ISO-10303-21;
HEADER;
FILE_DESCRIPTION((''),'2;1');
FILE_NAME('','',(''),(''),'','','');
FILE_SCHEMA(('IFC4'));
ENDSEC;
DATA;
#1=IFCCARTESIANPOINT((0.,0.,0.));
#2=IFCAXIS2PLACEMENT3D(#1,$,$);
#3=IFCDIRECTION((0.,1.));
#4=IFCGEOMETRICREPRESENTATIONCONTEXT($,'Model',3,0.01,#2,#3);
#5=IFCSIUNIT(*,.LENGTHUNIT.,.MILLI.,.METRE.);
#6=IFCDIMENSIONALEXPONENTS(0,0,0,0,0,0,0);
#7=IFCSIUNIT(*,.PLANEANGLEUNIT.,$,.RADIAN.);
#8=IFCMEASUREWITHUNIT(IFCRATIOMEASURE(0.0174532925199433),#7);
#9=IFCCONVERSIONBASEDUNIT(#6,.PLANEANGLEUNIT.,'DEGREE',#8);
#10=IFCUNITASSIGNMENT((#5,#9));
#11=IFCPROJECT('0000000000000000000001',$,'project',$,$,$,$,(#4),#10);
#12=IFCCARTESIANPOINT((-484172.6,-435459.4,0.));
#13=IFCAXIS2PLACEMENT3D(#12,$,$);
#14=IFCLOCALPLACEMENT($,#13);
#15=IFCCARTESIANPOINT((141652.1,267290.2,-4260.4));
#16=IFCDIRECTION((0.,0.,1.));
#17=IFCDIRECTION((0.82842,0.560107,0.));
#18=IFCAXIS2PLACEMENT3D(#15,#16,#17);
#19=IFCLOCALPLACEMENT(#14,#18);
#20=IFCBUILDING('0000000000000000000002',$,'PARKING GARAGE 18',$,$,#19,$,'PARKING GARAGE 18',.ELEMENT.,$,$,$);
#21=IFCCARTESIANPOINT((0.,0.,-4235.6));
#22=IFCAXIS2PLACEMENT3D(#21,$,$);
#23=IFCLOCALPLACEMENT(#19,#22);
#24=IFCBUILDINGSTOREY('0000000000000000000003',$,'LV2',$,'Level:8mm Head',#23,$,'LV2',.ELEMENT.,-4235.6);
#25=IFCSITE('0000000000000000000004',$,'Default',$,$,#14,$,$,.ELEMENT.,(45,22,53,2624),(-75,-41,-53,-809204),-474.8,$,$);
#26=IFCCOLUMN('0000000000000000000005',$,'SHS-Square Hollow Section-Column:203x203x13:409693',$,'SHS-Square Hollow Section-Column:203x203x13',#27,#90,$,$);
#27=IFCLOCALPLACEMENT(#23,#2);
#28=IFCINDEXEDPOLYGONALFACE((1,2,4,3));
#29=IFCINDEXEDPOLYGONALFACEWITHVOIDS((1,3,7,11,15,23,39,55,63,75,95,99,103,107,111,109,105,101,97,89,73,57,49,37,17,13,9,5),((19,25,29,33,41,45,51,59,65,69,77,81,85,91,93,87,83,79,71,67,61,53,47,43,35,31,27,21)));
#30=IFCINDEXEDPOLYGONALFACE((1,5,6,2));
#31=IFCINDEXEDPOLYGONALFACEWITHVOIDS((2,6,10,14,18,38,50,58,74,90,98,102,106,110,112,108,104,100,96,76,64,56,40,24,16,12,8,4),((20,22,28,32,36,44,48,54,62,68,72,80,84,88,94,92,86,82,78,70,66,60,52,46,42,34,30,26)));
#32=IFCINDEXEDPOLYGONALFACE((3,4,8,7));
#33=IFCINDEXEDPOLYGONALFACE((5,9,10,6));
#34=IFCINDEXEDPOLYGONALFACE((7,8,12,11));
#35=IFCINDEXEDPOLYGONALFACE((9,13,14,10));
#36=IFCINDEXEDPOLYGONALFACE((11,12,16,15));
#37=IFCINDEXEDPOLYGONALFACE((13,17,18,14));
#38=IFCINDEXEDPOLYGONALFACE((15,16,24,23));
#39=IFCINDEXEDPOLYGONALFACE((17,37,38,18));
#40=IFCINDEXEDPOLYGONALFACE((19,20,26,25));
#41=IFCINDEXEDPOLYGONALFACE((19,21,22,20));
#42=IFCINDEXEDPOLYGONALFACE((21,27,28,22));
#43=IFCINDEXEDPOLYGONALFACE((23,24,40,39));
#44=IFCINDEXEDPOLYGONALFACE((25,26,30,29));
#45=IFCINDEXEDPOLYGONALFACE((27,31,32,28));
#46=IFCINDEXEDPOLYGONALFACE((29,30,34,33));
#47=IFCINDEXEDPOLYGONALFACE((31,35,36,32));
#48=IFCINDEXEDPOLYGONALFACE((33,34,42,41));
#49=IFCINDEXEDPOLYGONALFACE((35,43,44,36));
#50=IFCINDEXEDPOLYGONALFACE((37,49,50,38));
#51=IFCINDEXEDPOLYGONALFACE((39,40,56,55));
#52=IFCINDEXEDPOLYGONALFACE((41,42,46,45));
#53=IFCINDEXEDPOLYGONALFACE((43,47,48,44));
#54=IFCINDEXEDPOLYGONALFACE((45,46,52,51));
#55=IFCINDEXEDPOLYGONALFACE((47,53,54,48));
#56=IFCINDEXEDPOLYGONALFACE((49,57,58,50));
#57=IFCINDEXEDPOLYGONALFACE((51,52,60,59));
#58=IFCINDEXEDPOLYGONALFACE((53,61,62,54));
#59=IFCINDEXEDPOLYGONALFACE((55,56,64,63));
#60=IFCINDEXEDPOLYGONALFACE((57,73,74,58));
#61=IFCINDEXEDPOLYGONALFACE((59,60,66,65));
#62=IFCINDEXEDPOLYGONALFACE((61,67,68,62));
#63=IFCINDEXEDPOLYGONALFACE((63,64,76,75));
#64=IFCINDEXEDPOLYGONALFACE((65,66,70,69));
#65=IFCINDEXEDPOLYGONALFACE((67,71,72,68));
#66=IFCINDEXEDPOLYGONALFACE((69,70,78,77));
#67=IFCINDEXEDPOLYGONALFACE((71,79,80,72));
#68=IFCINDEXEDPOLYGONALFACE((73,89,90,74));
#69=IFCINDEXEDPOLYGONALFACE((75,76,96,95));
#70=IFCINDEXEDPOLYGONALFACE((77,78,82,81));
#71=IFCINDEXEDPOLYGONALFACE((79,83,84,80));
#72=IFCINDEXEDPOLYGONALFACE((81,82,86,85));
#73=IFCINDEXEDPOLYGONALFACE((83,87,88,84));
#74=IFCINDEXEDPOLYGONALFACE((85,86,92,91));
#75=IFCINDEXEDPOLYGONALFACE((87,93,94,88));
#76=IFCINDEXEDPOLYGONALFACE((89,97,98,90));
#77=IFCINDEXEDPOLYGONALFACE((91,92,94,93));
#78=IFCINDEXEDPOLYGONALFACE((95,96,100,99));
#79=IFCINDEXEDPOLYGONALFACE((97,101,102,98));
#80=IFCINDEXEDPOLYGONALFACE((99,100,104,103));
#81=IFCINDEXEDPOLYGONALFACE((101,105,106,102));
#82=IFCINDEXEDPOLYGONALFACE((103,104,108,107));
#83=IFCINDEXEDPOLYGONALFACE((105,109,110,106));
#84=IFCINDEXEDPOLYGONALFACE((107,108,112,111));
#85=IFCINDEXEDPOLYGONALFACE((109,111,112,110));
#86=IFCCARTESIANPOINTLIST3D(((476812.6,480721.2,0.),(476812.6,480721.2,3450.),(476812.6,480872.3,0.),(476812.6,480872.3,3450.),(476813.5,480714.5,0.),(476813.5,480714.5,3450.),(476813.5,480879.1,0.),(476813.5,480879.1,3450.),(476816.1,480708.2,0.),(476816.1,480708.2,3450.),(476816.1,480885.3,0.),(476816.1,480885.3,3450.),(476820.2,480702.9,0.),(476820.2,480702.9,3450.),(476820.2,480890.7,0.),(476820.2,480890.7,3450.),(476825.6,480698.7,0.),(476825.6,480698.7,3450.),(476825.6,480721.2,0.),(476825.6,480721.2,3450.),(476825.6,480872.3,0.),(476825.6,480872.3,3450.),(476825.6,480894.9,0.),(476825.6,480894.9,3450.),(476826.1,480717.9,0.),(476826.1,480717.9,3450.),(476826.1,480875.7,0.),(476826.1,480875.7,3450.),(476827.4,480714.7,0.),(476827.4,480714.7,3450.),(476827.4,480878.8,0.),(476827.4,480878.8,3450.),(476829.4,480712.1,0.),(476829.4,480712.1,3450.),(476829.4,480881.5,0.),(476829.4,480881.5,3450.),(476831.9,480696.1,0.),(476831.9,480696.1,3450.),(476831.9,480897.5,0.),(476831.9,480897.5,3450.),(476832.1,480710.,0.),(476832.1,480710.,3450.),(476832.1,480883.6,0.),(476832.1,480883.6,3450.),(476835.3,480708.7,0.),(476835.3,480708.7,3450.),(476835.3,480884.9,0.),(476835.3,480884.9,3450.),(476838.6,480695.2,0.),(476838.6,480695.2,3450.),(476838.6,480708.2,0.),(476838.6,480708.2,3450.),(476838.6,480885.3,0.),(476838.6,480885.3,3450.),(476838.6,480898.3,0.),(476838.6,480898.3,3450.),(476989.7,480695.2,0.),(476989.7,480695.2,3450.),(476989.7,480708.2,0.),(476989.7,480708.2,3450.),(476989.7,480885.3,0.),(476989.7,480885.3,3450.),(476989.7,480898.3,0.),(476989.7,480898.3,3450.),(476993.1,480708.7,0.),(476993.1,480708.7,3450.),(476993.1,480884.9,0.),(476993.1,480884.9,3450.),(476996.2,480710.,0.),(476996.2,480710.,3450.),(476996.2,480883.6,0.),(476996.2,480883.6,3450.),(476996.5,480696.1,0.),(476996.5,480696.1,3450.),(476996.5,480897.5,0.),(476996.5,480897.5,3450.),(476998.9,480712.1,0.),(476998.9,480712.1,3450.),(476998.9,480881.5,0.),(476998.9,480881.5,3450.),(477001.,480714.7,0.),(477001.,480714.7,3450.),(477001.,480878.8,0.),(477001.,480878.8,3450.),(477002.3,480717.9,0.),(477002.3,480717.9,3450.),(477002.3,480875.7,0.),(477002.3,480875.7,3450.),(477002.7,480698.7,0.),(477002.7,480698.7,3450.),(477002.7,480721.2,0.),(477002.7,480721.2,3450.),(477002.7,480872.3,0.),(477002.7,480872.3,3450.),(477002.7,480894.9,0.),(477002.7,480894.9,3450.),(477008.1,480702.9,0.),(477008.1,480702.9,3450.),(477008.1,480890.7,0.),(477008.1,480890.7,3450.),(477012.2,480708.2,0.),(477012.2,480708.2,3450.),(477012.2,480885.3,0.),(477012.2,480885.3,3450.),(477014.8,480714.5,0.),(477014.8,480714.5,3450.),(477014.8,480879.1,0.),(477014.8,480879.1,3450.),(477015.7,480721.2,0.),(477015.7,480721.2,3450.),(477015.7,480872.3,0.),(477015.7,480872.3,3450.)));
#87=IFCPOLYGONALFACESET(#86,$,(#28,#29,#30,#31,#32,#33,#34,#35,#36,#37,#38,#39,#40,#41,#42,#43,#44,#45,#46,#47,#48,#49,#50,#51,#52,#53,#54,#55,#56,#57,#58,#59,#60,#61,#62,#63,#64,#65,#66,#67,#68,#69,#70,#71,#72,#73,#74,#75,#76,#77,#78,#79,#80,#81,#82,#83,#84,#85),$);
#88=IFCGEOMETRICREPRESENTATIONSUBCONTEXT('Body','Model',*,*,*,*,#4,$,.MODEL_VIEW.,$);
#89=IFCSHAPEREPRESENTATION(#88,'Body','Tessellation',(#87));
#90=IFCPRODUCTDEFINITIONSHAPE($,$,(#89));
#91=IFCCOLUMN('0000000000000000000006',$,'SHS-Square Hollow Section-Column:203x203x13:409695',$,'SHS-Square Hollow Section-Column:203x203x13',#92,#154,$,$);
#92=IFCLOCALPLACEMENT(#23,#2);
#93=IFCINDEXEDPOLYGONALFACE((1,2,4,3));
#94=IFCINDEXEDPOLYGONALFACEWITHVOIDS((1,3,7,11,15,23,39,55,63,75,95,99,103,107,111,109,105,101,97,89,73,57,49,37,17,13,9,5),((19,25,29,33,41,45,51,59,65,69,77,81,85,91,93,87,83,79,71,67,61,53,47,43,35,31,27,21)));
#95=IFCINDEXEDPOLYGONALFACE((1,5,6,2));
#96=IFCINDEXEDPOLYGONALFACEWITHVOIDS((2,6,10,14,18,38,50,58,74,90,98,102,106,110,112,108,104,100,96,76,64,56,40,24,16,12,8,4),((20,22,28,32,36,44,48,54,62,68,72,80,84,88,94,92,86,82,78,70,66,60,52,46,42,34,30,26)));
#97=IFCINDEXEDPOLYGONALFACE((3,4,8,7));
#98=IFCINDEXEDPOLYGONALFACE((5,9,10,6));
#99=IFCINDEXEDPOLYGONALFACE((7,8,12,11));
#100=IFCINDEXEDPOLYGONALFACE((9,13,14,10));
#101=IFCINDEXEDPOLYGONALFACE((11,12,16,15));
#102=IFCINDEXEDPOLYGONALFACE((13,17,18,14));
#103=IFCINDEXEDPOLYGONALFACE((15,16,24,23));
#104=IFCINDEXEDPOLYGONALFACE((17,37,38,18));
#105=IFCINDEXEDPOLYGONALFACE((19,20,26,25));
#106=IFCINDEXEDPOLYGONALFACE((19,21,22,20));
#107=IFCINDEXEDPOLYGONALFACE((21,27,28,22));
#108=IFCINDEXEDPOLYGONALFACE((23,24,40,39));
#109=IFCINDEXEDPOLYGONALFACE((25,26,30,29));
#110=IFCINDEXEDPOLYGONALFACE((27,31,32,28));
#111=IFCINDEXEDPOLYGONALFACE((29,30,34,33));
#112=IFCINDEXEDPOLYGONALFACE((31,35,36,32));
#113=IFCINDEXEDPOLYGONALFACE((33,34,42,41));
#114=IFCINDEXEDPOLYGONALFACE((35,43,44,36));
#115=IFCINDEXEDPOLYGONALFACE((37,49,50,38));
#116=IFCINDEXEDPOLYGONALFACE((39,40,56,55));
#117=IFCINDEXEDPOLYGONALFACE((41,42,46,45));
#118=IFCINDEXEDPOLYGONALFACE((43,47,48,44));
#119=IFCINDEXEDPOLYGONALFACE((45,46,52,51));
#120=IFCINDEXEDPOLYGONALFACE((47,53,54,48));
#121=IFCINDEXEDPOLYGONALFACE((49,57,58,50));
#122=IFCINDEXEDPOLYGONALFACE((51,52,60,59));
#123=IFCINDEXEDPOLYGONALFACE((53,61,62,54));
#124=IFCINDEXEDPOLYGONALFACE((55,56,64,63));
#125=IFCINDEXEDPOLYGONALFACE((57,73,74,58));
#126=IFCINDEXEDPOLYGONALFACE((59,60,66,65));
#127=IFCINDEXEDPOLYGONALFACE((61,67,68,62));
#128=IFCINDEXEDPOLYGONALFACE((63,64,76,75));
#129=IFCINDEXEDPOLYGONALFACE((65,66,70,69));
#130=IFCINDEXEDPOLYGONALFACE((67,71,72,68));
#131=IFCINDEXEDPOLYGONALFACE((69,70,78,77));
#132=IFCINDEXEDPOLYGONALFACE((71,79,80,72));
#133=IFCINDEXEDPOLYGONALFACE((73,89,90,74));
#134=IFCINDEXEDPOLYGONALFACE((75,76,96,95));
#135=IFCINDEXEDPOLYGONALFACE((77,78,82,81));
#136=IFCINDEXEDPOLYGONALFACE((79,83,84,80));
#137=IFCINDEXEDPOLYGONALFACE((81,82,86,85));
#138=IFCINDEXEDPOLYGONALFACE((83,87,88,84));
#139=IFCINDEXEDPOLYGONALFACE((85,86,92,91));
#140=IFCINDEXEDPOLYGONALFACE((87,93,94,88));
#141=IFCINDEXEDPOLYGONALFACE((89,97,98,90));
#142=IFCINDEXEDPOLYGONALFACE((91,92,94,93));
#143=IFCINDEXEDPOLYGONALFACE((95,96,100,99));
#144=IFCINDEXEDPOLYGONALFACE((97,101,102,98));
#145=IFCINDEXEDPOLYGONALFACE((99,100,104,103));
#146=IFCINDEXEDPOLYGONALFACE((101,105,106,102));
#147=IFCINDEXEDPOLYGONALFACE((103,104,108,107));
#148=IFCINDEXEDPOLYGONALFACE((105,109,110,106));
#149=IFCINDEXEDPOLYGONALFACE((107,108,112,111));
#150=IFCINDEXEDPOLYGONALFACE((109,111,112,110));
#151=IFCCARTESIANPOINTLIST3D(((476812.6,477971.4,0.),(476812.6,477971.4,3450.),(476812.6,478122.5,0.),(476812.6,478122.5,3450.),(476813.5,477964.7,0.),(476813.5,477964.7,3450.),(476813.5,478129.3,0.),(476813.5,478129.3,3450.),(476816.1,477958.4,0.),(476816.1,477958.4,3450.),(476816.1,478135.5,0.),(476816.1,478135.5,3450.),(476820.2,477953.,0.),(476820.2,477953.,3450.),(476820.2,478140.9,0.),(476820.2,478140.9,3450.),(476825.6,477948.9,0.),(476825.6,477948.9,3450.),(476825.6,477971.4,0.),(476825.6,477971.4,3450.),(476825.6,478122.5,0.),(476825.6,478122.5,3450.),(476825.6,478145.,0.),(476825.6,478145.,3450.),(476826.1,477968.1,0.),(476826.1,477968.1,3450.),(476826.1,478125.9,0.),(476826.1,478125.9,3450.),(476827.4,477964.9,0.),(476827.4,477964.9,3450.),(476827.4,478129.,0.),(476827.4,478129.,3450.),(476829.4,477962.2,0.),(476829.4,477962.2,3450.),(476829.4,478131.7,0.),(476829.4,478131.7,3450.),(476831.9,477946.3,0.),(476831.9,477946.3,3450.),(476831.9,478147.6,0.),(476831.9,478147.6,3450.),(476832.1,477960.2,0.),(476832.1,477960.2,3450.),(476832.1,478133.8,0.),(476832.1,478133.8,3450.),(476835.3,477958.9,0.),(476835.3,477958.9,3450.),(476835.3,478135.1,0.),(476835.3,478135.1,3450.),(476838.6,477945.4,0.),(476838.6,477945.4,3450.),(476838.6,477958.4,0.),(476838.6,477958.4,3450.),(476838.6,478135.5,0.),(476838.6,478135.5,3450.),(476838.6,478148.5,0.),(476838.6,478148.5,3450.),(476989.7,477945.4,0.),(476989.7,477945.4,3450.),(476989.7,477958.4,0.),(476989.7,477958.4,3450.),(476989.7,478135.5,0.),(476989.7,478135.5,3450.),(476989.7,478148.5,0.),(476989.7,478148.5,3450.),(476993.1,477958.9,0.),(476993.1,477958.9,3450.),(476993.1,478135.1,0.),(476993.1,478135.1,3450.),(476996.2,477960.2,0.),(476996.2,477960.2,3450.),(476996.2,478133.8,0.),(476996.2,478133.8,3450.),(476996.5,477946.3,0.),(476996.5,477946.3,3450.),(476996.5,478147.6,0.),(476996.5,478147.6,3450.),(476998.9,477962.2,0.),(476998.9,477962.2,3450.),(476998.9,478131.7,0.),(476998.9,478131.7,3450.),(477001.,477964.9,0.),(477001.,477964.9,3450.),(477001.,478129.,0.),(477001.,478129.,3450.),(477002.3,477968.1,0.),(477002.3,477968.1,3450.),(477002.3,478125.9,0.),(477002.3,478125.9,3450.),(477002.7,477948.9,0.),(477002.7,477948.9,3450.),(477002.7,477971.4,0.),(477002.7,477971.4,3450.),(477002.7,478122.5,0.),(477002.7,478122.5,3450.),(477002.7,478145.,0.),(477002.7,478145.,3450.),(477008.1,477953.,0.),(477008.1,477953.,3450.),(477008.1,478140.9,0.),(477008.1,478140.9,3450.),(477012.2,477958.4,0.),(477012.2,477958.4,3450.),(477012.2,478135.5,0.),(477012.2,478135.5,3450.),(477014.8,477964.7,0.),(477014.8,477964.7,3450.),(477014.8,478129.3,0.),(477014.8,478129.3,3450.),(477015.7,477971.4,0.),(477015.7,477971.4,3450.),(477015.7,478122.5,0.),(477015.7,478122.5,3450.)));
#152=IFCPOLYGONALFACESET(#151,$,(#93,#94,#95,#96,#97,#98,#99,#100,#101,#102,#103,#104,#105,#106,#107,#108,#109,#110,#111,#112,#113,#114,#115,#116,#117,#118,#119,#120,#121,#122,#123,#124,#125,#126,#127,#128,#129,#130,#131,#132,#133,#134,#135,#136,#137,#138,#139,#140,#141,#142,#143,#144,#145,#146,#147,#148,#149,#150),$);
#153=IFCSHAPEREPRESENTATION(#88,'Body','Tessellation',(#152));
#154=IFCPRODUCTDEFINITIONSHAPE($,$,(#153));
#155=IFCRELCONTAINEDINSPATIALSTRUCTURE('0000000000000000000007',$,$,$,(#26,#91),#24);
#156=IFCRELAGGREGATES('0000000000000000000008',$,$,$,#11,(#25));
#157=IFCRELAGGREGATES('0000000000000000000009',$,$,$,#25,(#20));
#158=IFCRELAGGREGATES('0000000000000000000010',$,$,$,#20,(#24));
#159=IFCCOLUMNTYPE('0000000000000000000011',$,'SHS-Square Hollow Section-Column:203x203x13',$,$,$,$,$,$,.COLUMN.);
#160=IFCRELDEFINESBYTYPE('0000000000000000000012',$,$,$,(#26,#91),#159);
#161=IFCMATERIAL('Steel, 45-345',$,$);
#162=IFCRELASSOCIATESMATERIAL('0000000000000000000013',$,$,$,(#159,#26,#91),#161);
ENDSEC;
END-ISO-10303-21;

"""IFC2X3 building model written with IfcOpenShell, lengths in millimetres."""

from ifc_helpers import new_model, entity, si_unit, converted_unit, direction, frame, frame_2d, origin, place, context, subcontext, project, spatial, polyline, circle_curve, parameter, trimmed, segment, composite_curve, outline, extrude, source, transform, mapped, material, type_object, type_shapes, element, save


model = new_model("IFC2X3")

# Units and contexts
model_context = context("Model", 3, precision=0.01, world=origin(), true_north=direction((0.0, 1.0)))
body_context = subcontext(model_context, "Body", "Model", "MODEL_VIEW")
ifc_project = project(units=[si_unit("LENGTHUNIT", "METRE", prefix="MILLI"), converted_unit("PLANEANGLEUNIT", "DEGREE", entity("IfcRatioMeasure", 0.0174532925199433), si_unit("PLANEANGLEUNIT", "RADIAN"), dimensions=[0, 0, 0, 0, 0, 0, 0])], contexts=[model_context])

# Site, building, storey
site_placement = place(None, frame((-484172.6, -435459.4, 0.0)))
site = spatial("IfcSite", under=ifc_project, at=site_placement, Name="Default", CompositionType="ELEMENT", RefLatitude=(45, 22, 53, 2624), RefLongitude=(-75, -41, -53, -809204), RefElevation=-474.8)
building_placement = place(site_placement, frame((141652.1, 267290.2, -4260.4), z_axis=(0.0, 0.0, 1.0), x_axis=(0.82842, 0.560107, 0.0)))
building = spatial("IfcBuilding", under=site, at=building_placement, Name="PARKING GARAGE 18", LongName="PARKING GARAGE 18", CompositionType="ELEMENT")
storey_placement = place(building_placement, frame((0.0, 0.0, -4235.6)))
storey = spatial("IfcBuildingStorey", under=building, at=storey_placement, Name="LV2", ObjectType="Level:8mm Head", LongName="LV2", CompositionType="ELEMENT", Elevation=-4235.6)

# Columns
ifc_material_1 = material(Name="Steel, 45-345")
column_type = type_object("IfcColumnType", Name="SHS-Square Hollow Section-Column:203x203x13", PredefinedType="COLUMN", material=ifc_material_1)
shared_shape_1 = source(origin(), body_context, "Body", "SweptSolid", [
    extrude(outline(composite_curve([segment(polyline([(-75.6, -101.5), (75.6, -101.5)]), True, "CONTINUOUS"), segment(trimmed(circle_curve(frame_2d((75.6, -75.6), x_axis=(-1.0, 0.0)), 26.0), [parameter(90.0)], [parameter(180.0)], True, "PARAMETER"), True, "CONTINUOUS"), segment(polyline([(101.5, -75.6), (101.5, 75.6)]), True, "CONTINUOUS"), segment(trimmed(circle_curve(frame_2d((75.5, 75.6), x_axis=(-1.0, 0.0)), 26.0), [parameter(180.0)], [parameter(270.0)], True, "PARAMETER"), True, "CONTINUOUS"), segment(polyline([(75.5, 101.6), (-75.5, 101.6)]), True, "CONTINUOUS"), segment(trimmed(circle_curve(frame_2d((-75.5, 75.5), x_axis=(-1.0, 0.0)), 26.0), [parameter(270.0)], [parameter(360.0)], True, "PARAMETER"), True, "CONTINUOUS"), segment(polyline([(-101.5, 75.5), (-101.5, -75.6)]), True, "CONTINUOUS"), segment(trimmed(circle_curve(frame_2d((-75.6, -75.6), x_axis=(-1.0, 0.0)), 26.0), [parameter(360.0)], [parameter(90.0)], True, "PARAMETER"), True, "CONTINUOUS")], self_intersect=False), holes=[composite_curve([segment(trimmed(circle_curve(frame_2d((-75.6, -75.6), x_axis=(-1.0, 0.0)), 13.0), [parameter(0.0)], [parameter(90.0)], True, "PARAMETER"), False, "CONTINUOUS"), segment(polyline([(-88.5, -75.6), (-88.5, 75.6)]), True, "CONTINUOUS"), segment(trimmed(circle_curve(frame_2d((-75.6, 75.6), x_axis=(-1.0, 0.0)), 13.0), [parameter(270.0)], [parameter(0.0)], True, "PARAMETER"), False, "CONTINUOUS"), segment(polyline([(-75.6, 88.6), (75.5, 88.6)]), True, "CONTINUOUS"), segment(trimmed(circle_curve(frame_2d((75.5, 75.5), x_axis=(-1.0, 0.0)), 13.0), [parameter(180.0)], [parameter(270.0)], True, "PARAMETER"), False, "CONTINUOUS"), segment(polyline([(88.6, 75.5), (88.6, -75.5)]), True, "CONTINUOUS"), segment(trimmed(circle_curve(frame_2d((75.6, -75.5), x_axis=(-1.0, 0.0)), 13.0), [parameter(90.0)], [parameter(180.0)], True, "PARAMETER"), False, "CONTINUOUS"), segment(polyline([(75.6, -88.5), (-75.6, -88.5)]), True, "CONTINUOUS")], self_intersect=False)]), frame((0.0, 0.0, -4235.6), z_axis=(0.0, 0.0, 1.0), x_axis=(-1.0, 0.0, 0.0)), (0.0, 0.0, 1.0), 3450.0),
])
type_shapes(column_type, [shared_shape_1])
for number, where, name in (
    (1, (476914.2, 480796.8, 4235.6), "SHS-Square Hollow Section-Column:203x203x13:409693"),
    (2, (476914.2, 478047.0, 4235.6), "SHS-Square Hollow Section-Column:203x203x13:409695"),
):
    element("IfcColumn", number, at=place(storey_placement, frame(where)), inside=storey, type_object=column_type, material=ifc_material_1, Name=name, ObjectType="SHS-Square Hollow Section-Column:203x203x13", context=body_context, shape_type="MappedRepresentation", body=[
        mapped(shared_shape_1, transform((0.0, 0.0, 0.0), scale=1.0)),
    ])

save(model, "model.ifc")
